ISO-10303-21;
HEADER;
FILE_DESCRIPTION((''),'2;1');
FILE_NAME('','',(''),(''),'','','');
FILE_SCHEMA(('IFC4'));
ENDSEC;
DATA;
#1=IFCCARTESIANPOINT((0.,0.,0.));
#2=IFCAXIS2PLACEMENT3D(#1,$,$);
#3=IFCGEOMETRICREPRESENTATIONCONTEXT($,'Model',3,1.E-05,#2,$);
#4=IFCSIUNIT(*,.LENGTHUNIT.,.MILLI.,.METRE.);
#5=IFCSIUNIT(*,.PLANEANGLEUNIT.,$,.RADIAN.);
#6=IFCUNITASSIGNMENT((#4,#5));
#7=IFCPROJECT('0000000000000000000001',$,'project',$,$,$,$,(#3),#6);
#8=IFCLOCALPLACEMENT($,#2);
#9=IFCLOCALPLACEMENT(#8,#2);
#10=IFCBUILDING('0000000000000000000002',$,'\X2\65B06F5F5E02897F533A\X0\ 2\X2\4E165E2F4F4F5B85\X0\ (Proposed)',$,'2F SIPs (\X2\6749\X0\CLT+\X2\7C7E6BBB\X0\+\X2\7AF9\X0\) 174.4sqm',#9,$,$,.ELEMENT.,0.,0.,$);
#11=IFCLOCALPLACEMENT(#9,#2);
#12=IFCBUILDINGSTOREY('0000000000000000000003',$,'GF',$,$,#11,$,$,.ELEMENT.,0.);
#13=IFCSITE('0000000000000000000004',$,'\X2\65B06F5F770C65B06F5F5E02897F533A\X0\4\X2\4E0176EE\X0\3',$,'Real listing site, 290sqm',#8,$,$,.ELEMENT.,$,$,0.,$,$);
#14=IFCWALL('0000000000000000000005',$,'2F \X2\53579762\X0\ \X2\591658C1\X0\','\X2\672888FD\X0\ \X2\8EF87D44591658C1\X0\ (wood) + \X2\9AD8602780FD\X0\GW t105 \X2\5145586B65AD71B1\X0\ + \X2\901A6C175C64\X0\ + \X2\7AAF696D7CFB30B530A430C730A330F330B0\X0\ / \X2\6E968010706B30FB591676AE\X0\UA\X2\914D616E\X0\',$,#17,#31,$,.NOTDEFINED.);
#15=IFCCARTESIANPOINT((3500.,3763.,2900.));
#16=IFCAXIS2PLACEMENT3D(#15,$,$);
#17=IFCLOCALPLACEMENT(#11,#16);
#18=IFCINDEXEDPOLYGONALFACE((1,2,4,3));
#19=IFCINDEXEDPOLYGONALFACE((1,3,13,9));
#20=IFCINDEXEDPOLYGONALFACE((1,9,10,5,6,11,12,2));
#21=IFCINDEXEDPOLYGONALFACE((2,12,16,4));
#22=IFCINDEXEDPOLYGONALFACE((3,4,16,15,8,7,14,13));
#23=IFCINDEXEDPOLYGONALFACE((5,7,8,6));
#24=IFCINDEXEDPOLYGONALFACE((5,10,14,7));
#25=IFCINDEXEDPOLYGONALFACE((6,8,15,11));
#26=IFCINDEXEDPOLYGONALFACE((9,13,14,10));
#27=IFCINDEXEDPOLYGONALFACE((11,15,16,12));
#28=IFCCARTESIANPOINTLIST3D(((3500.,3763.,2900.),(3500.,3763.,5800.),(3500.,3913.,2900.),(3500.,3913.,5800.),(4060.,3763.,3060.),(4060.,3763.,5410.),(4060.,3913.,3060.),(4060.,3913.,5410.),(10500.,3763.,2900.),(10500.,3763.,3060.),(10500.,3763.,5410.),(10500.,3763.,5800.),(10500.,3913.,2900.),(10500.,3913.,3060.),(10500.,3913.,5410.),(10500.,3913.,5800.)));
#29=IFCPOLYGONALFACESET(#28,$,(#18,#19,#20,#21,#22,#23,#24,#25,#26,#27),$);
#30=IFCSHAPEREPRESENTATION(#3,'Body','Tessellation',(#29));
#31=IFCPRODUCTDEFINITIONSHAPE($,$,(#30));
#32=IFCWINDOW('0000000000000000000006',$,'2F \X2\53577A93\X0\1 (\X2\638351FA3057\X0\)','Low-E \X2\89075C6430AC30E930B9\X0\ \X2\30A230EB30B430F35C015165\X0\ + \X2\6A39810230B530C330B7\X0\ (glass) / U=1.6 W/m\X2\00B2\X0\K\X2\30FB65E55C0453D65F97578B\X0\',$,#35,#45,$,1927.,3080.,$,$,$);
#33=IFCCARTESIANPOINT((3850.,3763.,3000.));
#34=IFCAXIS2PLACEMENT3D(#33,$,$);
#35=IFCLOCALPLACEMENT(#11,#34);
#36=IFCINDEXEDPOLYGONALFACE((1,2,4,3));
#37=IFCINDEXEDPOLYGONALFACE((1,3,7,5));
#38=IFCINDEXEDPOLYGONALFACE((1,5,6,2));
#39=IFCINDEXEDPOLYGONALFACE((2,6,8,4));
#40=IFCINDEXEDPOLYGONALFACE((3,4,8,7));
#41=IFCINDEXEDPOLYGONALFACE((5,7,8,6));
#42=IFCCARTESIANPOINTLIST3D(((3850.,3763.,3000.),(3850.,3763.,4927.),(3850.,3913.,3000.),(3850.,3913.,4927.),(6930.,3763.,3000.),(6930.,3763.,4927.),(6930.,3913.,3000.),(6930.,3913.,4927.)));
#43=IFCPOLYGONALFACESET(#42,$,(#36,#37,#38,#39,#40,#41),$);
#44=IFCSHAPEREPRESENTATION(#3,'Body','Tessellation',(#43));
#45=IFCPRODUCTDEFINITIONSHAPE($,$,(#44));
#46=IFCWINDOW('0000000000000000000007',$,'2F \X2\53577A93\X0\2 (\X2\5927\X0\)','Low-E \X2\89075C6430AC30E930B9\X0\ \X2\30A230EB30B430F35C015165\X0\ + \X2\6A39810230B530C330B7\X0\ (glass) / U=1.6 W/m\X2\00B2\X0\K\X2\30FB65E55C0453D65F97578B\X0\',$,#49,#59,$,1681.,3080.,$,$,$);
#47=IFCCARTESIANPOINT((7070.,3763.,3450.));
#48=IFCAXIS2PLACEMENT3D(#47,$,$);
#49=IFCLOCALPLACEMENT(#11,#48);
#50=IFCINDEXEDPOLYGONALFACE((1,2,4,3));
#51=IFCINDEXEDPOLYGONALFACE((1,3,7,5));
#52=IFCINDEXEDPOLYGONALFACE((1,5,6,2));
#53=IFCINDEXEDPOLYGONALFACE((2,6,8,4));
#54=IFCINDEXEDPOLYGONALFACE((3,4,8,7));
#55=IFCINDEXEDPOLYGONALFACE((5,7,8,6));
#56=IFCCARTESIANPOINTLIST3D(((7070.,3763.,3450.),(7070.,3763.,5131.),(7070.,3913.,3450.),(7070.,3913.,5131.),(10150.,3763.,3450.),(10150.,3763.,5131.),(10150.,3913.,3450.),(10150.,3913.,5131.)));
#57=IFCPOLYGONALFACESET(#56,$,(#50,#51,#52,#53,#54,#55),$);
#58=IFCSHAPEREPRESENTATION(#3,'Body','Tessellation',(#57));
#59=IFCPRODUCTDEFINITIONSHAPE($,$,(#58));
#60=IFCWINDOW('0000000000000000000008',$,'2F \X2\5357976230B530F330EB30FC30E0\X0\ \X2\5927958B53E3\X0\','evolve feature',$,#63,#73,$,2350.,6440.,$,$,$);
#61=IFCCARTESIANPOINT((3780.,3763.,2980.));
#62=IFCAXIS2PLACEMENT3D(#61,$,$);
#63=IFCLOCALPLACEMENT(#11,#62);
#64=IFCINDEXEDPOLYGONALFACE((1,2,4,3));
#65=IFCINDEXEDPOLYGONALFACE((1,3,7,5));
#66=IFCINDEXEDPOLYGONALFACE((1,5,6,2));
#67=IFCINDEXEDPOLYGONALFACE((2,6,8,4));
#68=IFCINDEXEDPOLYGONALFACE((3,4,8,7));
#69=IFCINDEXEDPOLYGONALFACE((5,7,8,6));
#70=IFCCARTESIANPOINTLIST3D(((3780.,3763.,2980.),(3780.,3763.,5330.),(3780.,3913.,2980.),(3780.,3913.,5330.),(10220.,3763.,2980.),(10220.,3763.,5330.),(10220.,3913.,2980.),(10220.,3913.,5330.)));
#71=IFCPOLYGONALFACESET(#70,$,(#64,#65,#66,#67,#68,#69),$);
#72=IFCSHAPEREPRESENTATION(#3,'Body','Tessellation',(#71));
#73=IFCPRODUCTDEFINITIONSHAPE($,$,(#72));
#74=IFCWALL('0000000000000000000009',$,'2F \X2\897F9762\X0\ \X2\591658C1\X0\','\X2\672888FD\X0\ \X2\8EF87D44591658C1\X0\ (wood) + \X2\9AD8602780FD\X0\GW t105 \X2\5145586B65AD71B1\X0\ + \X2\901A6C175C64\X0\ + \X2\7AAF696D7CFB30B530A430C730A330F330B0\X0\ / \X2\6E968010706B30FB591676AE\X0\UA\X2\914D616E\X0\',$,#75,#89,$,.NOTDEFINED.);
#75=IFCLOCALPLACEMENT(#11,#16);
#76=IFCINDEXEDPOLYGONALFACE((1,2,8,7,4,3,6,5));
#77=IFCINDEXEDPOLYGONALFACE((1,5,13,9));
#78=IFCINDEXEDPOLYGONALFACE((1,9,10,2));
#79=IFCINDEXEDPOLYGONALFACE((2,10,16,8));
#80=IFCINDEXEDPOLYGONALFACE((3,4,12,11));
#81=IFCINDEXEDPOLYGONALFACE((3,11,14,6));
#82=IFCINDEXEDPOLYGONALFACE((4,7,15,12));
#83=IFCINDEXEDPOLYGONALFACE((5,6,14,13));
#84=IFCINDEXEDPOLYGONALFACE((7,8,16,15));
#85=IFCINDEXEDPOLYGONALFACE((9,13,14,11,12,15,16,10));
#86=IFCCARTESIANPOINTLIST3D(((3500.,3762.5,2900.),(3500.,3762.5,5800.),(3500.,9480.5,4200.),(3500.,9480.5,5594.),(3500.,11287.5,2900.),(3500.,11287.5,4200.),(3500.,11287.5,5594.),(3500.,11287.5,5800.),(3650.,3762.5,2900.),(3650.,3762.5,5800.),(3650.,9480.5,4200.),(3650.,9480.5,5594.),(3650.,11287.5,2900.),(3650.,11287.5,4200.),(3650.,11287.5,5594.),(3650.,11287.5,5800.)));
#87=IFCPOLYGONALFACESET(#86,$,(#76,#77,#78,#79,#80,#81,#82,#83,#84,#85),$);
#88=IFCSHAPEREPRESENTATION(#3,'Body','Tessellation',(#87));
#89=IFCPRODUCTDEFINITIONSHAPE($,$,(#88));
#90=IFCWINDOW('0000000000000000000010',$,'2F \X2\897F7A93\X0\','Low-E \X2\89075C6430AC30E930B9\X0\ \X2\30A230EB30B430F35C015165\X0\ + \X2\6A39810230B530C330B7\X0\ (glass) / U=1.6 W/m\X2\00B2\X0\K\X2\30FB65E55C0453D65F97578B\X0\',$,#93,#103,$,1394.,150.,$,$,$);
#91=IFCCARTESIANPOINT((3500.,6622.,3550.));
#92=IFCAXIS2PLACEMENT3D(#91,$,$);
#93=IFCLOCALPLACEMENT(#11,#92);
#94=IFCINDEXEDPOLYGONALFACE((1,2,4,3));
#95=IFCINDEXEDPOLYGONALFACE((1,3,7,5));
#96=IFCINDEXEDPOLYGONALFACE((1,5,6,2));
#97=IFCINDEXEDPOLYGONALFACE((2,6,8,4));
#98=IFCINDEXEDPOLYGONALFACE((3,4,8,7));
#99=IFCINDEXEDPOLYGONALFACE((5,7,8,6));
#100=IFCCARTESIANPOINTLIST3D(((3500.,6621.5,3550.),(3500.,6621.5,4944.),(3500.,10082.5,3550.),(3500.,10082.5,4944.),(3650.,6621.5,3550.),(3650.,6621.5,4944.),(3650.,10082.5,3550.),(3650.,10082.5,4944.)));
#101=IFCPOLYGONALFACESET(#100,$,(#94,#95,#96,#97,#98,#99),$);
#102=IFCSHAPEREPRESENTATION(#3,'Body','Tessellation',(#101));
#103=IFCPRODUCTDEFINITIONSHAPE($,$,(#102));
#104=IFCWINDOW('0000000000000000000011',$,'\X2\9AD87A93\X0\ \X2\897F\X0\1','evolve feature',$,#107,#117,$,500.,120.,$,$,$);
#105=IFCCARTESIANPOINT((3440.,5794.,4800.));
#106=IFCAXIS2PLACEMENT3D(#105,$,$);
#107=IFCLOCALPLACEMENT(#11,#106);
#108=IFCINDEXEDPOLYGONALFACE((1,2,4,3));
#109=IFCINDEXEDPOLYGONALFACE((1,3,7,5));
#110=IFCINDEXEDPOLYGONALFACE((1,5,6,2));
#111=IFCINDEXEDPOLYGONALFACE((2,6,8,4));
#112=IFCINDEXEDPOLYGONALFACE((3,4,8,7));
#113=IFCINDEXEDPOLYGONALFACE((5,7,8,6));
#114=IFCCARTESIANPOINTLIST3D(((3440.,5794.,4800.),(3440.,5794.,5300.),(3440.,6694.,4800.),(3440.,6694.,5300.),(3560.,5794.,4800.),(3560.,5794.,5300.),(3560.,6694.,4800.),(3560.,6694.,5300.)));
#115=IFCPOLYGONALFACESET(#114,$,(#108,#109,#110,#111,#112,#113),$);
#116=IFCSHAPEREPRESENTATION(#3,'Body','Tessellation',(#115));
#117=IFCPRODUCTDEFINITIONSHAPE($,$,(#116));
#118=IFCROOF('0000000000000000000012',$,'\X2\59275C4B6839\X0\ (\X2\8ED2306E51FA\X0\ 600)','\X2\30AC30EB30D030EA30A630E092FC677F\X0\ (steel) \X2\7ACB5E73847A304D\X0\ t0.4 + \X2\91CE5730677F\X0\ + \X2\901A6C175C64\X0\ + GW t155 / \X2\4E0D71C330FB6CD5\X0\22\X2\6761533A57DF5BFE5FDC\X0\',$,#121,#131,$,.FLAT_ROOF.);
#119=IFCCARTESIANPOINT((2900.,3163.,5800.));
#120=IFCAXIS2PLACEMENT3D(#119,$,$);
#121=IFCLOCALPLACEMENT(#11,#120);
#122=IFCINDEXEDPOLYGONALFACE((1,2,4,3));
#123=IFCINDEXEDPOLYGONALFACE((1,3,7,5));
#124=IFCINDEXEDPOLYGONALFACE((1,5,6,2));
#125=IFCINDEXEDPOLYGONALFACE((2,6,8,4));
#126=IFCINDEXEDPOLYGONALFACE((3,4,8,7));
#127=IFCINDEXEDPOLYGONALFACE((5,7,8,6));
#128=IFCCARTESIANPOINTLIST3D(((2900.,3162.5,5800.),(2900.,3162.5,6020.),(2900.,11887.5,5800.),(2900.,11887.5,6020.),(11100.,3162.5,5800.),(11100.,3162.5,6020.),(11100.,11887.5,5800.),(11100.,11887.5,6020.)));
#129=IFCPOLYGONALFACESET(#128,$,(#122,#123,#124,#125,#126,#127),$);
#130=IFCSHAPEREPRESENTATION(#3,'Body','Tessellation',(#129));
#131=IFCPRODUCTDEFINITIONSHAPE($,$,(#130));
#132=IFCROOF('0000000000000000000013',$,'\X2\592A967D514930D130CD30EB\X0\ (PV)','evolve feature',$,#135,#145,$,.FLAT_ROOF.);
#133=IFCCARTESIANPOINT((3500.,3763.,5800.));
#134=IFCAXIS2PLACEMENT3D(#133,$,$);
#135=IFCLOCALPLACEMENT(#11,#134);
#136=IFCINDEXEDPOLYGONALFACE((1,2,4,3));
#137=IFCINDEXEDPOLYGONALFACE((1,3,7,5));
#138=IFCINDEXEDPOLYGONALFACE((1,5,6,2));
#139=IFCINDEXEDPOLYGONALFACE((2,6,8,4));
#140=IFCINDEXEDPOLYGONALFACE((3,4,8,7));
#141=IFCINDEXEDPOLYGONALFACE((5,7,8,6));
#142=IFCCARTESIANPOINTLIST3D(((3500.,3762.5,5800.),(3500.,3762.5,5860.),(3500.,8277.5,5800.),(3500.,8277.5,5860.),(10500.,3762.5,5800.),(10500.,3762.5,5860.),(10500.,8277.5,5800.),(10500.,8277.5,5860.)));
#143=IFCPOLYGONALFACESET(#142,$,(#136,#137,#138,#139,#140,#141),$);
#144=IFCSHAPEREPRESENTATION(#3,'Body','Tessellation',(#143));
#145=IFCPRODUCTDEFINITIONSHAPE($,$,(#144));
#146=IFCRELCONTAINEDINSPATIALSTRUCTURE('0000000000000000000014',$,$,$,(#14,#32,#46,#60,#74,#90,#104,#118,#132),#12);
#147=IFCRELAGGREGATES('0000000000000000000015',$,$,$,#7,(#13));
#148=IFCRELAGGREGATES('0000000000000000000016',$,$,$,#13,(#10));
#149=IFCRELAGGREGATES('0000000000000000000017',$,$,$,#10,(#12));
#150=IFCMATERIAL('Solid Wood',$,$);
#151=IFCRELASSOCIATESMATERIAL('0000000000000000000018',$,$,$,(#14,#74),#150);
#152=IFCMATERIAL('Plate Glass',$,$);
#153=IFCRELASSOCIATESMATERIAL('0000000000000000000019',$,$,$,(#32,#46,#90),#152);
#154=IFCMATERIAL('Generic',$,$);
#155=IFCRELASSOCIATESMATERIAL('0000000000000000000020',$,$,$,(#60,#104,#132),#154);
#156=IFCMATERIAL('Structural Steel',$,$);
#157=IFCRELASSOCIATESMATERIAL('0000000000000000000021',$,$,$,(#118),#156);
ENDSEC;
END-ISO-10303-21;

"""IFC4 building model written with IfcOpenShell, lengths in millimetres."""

from ifc_helpers import new_model, si_unit, frame, frame_2d, origin, place, context, project, spatial, rectangle, extrude, material, element, fill, save


model = new_model("IFC4")

# Units and contexts
model_context = context("Model", 3, precision=1e-05, world=origin())
ifc_project = project(units=[si_unit("LENGTHUNIT", "METRE", prefix="MILLI"), si_unit("PLANEANGLEUNIT", "RADIAN")], contexts=[model_context])

# Site, building, storey
site_placement = place(None, origin())
site = spatial("IfcSite", under=ifc_project, at=site_placement, Name="新潟県新潟市西区4丁目3", ObjectType="Real listing site, 290sqm", CompositionType="ELEMENT", RefElevation=0.0)
building_placement = place(site_placement, origin())
building = spatial("IfcBuilding", under=site, at=building_placement, Name="新潟市西区 2世帯住宅 (Proposed)", ObjectType="2F SIPs (杉CLT+籾殻+竹) 174.4sqm", CompositionType="ELEMENT", ElevationOfRefHeight=0.0, ElevationOfTerrain=0.0)
storey_placement = place(building_placement, origin())
storey = spatial("IfcBuildingStorey", under=building, at=storey_placement, Name="GF", CompositionType="ELEMENT", Elevation=0.0)

# Shared definitions
ifc_material_1 = material(Name="Solid Wood")
ifc_material_2 = material(Name="Generic")

# Shared definitions
ifc_material_3 = material(Name="Plate Glass")

# Walls, openings, windows
wall_1_placement = place(storey_placement, frame((3500.0, 3763.0, 2900.0)))
wall_1 = element("IfcWall", 1, at=wall_1_placement, inside=storey, material=ifc_material_1, Name="2F 南面 外壁", Description="木製 軸組外壁 (wood) + 高性能GW t105 充填断熱 + 通気層 + 窯業系サイディング / 準耐火・外皮UA配慮", PredefinedType="NOTDEFINED", context=model_context, shape_type="SweptSolid", body=[
    extrude(rectangle(XDim=7000.0, YDim=150.0, at=frame_2d((3500.0, 75.0))), frame((3500.0, 3763.0, 2900.0)), (0.0, 0.0, 1.0), 2900.0),
])
opening_1_placement = place(storey_placement, frame((3850.0, 3763.0, 3000.0)))
opening_1 = element("IfcOpeningElement", 2, at=opening_1_placement, cuts=wall_1, PredefinedType="NOTDEFINED", context=model_context, shape_type="SweptSolid", body=[
    extrude(rectangle(XDim=3080.0, YDim=150.0, at=frame_2d((1540.0, 75.0))), frame((3850.0, 3763.0, 3000.0)), (0.0, 0.0, 1.0), 1927.0),
])
opening_2_placement = place(storey_placement, frame((7070.0, 3763.0, 3450.0)))
opening_2 = element("IfcOpeningElement", 3, at=opening_2_placement, cuts=wall_1, PredefinedType="NOTDEFINED", context=model_context, shape_type="SweptSolid", body=[
    extrude(rectangle(XDim=3080.0, YDim=150.0, at=frame_2d((1540.0, 75.0))), frame((7070.0, 3763.0, 3450.0)), (0.0, 0.0, 1.0), 1681.0),
])
opening_3_placement = place(storey_placement, frame((3780.0, 3763.0, 2980.0)))
opening_3 = element("IfcOpeningElement", 4, at=opening_3_placement, cuts=wall_1, PredefinedType="NOTDEFINED", context=model_context, shape_type="SweptSolid", body=[
    extrude(rectangle(XDim=6440.0, YDim=150.0, at=frame_2d((3220.0, 75.0))), frame((3780.0, 3763.0, 2980.0)), (0.0, 0.0, 1.0), 2350.0),
])
window_1_placement = place(storey_placement, frame((3850.0, 3763.0, 3000.0)))
window_1 = element("IfcWindow", 5, at=window_1_placement, inside=storey, material=ifc_material_3, Name="2F 南窓1 (掃出し)", Description="Low-E 複層ガラス アルゴン封入 + 樹脂サッシ (glass) / U=1.6 W/m²K・日射取得型", OverallHeight=1927.0, OverallWidth=3080.0, context=model_context, shape_type="SweptSolid", body=[
    extrude(rectangle(XDim=3080.0, YDim=150.0, at=frame_2d((1540.0, 75.0))), frame((3850.0, 3763.0, 3000.0)), (0.0, 0.0, 1.0), 1927.0),
])
fill(opening_1, window_1)
window_2_placement = place(storey_placement, frame((7070.0, 3763.0, 3450.0)))
window_2 = element("IfcWindow", 6, at=window_2_placement, inside=storey, material=ifc_material_3, Name="2F 南窓2 (大)", Description="Low-E 複層ガラス アルゴン封入 + 樹脂サッシ (glass) / U=1.6 W/m²K・日射取得型", OverallHeight=1681.0, OverallWidth=3080.0, context=model_context, shape_type="SweptSolid", body=[
    extrude(rectangle(XDim=3080.0, YDim=150.0, at=frame_2d((1540.0, 75.0))), frame((7070.0, 3763.0, 3450.0)), (0.0, 0.0, 1.0), 1681.0),
])
fill(opening_2, window_2)
window_3_placement = place(storey_placement, frame((3780.0, 3763.0, 2980.0)))
window_3 = element("IfcWindow", 7, at=window_3_placement, inside=storey, material=ifc_material_2, Name="2F 南面サンルーム 大開口", Description="evolve feature", OverallHeight=2350.0, OverallWidth=6440.0, context=model_context, shape_type="SweptSolid", body=[
    extrude(rectangle(XDim=6440.0, YDim=150.0, at=frame_2d((3220.0, 75.0))), frame((3780.0, 3763.0, 2980.0)), (0.0, 0.0, 1.0), 2350.0),
])
fill(opening_3, window_3)
wall_2_placement = place(storey_placement, frame((3500.0, 3763.0, 2900.0)))
wall_2 = element("IfcWall", 8, at=wall_2_placement, inside=storey, material=ifc_material_1, Name="2F 西面 外壁", Description="木製 軸組外壁 (wood) + 高性能GW t105 充填断熱 + 通気層 + 窯業系サイディング / 準耐火・外皮UA配慮", PredefinedType="NOTDEFINED", context=model_context, shape_type="SweptSolid", body=[
    extrude(rectangle(XDim=150.0, YDim=7525.0, at=frame_2d((75.0, 3762.0))), frame((3500.0, 3763.0, 2900.0)), (0.0, 0.0, 1.0), 2900.0),
])
opening_4_placement = place(storey_placement, frame((3500.0, 6622.0, 3550.0)))
opening_4 = element("IfcOpeningElement", 9, at=opening_4_placement, cuts=wall_2, PredefinedType="NOTDEFINED", context=model_context, shape_type="SweptSolid", body=[
    extrude(rectangle(XDim=150.0, YDim=3461.0, at=frame_2d((75.0, 1730.0))), frame((3500.0, 6622.0, 3550.0)), (0.0, 0.0, 1.0), 1394.0),
])
opening_5_placement = place(storey_placement, frame((3440.0, 5794.0, 4800.0)))
opening_5 = element("IfcOpeningElement", 10, at=opening_5_placement, cuts=wall_2, PredefinedType="NOTDEFINED", context=model_context, shape_type="SweptSolid", body=[
    extrude(rectangle(XDim=120.0, YDim=900.0, at=frame_2d((60.0, 450.0))), frame((3440.0, 5794.0, 4800.0)), (0.0, 0.0, 1.0), 500.0),
])
window_4_placement = place(storey_placement, frame((3500.0, 6622.0, 3550.0)))
window_4 = element("IfcWindow", 11, at=window_4_placement, inside=storey, material=ifc_material_3, Name="2F 西窓", Description="Low-E 複層ガラス アルゴン封入 + 樹脂サッシ (glass) / U=1.6 W/m²K・日射取得型", OverallHeight=1394.0, OverallWidth=150.0, context=model_context, shape_type="SweptSolid", body=[
    extrude(rectangle(XDim=150.0, YDim=3461.0, at=frame_2d((75.0, 1730.0))), frame((3500.0, 6622.0, 3550.0)), (0.0, 0.0, 1.0), 1394.0),
])
fill(opening_4, window_4)
window_5_placement = place(storey_placement, frame((3440.0, 5794.0, 4800.0)))
window_5 = element("IfcWindow", 12, at=window_5_placement, inside=storey, material=ifc_material_2, Name="高窓 西1", Description="evolve feature", OverallHeight=500.0, OverallWidth=120.0, context=model_context, shape_type="SweptSolid", body=[
    extrude(rectangle(XDim=120.0, YDim=900.0, at=frame_2d((60.0, 450.0))), frame((3440.0, 5794.0, 4800.0)), (0.0, 0.0, 1.0), 500.0),
])
fill(opening_5, window_5)

# Roofs
ifc_material_4 = material(Name="Structural Steel")
roof_1_placement = place(storey_placement, frame((2900.0, 3163.0, 5800.0)))
element("IfcRoof", 13, at=roof_1_placement, inside=storey, material=ifc_material_4, Name="大屋根 (軒の出 600)", Description="ガルバリウム鋼板 (steel) 立平葺き t0.4 + 野地板 + 通気層 + GW t155 / 不燃・法22条区域対応", PredefinedType="FLAT_ROOF", context=model_context, shape_type="SweptSolid", body=[
    extrude(rectangle(XDim=8200.0, YDim=8725.0, at=frame_2d((4100.0, 4362.0))), frame((2900.0, 3163.0, 5800.0)), (0.0, 0.0, 1.0), 220.0),
])
roof_2_placement = place(storey_placement, frame((3500.0, 3763.0, 5800.0)))
element("IfcRoof", 14, at=roof_2_placement, inside=storey, material=ifc_material_2, Name="太陽光パネル (PV)", Description="evolve feature", PredefinedType="FLAT_ROOF", context=model_context, shape_type="SweptSolid", body=[
    extrude(rectangle(XDim=7000.0, YDim=4515.0, at=frame_2d((3500.0, 2257.0))), frame((3500.0, 3763.0, 5800.0)), (0.0, 0.0, 1.0), 60.0),
])

save(model, "model.ifc")
